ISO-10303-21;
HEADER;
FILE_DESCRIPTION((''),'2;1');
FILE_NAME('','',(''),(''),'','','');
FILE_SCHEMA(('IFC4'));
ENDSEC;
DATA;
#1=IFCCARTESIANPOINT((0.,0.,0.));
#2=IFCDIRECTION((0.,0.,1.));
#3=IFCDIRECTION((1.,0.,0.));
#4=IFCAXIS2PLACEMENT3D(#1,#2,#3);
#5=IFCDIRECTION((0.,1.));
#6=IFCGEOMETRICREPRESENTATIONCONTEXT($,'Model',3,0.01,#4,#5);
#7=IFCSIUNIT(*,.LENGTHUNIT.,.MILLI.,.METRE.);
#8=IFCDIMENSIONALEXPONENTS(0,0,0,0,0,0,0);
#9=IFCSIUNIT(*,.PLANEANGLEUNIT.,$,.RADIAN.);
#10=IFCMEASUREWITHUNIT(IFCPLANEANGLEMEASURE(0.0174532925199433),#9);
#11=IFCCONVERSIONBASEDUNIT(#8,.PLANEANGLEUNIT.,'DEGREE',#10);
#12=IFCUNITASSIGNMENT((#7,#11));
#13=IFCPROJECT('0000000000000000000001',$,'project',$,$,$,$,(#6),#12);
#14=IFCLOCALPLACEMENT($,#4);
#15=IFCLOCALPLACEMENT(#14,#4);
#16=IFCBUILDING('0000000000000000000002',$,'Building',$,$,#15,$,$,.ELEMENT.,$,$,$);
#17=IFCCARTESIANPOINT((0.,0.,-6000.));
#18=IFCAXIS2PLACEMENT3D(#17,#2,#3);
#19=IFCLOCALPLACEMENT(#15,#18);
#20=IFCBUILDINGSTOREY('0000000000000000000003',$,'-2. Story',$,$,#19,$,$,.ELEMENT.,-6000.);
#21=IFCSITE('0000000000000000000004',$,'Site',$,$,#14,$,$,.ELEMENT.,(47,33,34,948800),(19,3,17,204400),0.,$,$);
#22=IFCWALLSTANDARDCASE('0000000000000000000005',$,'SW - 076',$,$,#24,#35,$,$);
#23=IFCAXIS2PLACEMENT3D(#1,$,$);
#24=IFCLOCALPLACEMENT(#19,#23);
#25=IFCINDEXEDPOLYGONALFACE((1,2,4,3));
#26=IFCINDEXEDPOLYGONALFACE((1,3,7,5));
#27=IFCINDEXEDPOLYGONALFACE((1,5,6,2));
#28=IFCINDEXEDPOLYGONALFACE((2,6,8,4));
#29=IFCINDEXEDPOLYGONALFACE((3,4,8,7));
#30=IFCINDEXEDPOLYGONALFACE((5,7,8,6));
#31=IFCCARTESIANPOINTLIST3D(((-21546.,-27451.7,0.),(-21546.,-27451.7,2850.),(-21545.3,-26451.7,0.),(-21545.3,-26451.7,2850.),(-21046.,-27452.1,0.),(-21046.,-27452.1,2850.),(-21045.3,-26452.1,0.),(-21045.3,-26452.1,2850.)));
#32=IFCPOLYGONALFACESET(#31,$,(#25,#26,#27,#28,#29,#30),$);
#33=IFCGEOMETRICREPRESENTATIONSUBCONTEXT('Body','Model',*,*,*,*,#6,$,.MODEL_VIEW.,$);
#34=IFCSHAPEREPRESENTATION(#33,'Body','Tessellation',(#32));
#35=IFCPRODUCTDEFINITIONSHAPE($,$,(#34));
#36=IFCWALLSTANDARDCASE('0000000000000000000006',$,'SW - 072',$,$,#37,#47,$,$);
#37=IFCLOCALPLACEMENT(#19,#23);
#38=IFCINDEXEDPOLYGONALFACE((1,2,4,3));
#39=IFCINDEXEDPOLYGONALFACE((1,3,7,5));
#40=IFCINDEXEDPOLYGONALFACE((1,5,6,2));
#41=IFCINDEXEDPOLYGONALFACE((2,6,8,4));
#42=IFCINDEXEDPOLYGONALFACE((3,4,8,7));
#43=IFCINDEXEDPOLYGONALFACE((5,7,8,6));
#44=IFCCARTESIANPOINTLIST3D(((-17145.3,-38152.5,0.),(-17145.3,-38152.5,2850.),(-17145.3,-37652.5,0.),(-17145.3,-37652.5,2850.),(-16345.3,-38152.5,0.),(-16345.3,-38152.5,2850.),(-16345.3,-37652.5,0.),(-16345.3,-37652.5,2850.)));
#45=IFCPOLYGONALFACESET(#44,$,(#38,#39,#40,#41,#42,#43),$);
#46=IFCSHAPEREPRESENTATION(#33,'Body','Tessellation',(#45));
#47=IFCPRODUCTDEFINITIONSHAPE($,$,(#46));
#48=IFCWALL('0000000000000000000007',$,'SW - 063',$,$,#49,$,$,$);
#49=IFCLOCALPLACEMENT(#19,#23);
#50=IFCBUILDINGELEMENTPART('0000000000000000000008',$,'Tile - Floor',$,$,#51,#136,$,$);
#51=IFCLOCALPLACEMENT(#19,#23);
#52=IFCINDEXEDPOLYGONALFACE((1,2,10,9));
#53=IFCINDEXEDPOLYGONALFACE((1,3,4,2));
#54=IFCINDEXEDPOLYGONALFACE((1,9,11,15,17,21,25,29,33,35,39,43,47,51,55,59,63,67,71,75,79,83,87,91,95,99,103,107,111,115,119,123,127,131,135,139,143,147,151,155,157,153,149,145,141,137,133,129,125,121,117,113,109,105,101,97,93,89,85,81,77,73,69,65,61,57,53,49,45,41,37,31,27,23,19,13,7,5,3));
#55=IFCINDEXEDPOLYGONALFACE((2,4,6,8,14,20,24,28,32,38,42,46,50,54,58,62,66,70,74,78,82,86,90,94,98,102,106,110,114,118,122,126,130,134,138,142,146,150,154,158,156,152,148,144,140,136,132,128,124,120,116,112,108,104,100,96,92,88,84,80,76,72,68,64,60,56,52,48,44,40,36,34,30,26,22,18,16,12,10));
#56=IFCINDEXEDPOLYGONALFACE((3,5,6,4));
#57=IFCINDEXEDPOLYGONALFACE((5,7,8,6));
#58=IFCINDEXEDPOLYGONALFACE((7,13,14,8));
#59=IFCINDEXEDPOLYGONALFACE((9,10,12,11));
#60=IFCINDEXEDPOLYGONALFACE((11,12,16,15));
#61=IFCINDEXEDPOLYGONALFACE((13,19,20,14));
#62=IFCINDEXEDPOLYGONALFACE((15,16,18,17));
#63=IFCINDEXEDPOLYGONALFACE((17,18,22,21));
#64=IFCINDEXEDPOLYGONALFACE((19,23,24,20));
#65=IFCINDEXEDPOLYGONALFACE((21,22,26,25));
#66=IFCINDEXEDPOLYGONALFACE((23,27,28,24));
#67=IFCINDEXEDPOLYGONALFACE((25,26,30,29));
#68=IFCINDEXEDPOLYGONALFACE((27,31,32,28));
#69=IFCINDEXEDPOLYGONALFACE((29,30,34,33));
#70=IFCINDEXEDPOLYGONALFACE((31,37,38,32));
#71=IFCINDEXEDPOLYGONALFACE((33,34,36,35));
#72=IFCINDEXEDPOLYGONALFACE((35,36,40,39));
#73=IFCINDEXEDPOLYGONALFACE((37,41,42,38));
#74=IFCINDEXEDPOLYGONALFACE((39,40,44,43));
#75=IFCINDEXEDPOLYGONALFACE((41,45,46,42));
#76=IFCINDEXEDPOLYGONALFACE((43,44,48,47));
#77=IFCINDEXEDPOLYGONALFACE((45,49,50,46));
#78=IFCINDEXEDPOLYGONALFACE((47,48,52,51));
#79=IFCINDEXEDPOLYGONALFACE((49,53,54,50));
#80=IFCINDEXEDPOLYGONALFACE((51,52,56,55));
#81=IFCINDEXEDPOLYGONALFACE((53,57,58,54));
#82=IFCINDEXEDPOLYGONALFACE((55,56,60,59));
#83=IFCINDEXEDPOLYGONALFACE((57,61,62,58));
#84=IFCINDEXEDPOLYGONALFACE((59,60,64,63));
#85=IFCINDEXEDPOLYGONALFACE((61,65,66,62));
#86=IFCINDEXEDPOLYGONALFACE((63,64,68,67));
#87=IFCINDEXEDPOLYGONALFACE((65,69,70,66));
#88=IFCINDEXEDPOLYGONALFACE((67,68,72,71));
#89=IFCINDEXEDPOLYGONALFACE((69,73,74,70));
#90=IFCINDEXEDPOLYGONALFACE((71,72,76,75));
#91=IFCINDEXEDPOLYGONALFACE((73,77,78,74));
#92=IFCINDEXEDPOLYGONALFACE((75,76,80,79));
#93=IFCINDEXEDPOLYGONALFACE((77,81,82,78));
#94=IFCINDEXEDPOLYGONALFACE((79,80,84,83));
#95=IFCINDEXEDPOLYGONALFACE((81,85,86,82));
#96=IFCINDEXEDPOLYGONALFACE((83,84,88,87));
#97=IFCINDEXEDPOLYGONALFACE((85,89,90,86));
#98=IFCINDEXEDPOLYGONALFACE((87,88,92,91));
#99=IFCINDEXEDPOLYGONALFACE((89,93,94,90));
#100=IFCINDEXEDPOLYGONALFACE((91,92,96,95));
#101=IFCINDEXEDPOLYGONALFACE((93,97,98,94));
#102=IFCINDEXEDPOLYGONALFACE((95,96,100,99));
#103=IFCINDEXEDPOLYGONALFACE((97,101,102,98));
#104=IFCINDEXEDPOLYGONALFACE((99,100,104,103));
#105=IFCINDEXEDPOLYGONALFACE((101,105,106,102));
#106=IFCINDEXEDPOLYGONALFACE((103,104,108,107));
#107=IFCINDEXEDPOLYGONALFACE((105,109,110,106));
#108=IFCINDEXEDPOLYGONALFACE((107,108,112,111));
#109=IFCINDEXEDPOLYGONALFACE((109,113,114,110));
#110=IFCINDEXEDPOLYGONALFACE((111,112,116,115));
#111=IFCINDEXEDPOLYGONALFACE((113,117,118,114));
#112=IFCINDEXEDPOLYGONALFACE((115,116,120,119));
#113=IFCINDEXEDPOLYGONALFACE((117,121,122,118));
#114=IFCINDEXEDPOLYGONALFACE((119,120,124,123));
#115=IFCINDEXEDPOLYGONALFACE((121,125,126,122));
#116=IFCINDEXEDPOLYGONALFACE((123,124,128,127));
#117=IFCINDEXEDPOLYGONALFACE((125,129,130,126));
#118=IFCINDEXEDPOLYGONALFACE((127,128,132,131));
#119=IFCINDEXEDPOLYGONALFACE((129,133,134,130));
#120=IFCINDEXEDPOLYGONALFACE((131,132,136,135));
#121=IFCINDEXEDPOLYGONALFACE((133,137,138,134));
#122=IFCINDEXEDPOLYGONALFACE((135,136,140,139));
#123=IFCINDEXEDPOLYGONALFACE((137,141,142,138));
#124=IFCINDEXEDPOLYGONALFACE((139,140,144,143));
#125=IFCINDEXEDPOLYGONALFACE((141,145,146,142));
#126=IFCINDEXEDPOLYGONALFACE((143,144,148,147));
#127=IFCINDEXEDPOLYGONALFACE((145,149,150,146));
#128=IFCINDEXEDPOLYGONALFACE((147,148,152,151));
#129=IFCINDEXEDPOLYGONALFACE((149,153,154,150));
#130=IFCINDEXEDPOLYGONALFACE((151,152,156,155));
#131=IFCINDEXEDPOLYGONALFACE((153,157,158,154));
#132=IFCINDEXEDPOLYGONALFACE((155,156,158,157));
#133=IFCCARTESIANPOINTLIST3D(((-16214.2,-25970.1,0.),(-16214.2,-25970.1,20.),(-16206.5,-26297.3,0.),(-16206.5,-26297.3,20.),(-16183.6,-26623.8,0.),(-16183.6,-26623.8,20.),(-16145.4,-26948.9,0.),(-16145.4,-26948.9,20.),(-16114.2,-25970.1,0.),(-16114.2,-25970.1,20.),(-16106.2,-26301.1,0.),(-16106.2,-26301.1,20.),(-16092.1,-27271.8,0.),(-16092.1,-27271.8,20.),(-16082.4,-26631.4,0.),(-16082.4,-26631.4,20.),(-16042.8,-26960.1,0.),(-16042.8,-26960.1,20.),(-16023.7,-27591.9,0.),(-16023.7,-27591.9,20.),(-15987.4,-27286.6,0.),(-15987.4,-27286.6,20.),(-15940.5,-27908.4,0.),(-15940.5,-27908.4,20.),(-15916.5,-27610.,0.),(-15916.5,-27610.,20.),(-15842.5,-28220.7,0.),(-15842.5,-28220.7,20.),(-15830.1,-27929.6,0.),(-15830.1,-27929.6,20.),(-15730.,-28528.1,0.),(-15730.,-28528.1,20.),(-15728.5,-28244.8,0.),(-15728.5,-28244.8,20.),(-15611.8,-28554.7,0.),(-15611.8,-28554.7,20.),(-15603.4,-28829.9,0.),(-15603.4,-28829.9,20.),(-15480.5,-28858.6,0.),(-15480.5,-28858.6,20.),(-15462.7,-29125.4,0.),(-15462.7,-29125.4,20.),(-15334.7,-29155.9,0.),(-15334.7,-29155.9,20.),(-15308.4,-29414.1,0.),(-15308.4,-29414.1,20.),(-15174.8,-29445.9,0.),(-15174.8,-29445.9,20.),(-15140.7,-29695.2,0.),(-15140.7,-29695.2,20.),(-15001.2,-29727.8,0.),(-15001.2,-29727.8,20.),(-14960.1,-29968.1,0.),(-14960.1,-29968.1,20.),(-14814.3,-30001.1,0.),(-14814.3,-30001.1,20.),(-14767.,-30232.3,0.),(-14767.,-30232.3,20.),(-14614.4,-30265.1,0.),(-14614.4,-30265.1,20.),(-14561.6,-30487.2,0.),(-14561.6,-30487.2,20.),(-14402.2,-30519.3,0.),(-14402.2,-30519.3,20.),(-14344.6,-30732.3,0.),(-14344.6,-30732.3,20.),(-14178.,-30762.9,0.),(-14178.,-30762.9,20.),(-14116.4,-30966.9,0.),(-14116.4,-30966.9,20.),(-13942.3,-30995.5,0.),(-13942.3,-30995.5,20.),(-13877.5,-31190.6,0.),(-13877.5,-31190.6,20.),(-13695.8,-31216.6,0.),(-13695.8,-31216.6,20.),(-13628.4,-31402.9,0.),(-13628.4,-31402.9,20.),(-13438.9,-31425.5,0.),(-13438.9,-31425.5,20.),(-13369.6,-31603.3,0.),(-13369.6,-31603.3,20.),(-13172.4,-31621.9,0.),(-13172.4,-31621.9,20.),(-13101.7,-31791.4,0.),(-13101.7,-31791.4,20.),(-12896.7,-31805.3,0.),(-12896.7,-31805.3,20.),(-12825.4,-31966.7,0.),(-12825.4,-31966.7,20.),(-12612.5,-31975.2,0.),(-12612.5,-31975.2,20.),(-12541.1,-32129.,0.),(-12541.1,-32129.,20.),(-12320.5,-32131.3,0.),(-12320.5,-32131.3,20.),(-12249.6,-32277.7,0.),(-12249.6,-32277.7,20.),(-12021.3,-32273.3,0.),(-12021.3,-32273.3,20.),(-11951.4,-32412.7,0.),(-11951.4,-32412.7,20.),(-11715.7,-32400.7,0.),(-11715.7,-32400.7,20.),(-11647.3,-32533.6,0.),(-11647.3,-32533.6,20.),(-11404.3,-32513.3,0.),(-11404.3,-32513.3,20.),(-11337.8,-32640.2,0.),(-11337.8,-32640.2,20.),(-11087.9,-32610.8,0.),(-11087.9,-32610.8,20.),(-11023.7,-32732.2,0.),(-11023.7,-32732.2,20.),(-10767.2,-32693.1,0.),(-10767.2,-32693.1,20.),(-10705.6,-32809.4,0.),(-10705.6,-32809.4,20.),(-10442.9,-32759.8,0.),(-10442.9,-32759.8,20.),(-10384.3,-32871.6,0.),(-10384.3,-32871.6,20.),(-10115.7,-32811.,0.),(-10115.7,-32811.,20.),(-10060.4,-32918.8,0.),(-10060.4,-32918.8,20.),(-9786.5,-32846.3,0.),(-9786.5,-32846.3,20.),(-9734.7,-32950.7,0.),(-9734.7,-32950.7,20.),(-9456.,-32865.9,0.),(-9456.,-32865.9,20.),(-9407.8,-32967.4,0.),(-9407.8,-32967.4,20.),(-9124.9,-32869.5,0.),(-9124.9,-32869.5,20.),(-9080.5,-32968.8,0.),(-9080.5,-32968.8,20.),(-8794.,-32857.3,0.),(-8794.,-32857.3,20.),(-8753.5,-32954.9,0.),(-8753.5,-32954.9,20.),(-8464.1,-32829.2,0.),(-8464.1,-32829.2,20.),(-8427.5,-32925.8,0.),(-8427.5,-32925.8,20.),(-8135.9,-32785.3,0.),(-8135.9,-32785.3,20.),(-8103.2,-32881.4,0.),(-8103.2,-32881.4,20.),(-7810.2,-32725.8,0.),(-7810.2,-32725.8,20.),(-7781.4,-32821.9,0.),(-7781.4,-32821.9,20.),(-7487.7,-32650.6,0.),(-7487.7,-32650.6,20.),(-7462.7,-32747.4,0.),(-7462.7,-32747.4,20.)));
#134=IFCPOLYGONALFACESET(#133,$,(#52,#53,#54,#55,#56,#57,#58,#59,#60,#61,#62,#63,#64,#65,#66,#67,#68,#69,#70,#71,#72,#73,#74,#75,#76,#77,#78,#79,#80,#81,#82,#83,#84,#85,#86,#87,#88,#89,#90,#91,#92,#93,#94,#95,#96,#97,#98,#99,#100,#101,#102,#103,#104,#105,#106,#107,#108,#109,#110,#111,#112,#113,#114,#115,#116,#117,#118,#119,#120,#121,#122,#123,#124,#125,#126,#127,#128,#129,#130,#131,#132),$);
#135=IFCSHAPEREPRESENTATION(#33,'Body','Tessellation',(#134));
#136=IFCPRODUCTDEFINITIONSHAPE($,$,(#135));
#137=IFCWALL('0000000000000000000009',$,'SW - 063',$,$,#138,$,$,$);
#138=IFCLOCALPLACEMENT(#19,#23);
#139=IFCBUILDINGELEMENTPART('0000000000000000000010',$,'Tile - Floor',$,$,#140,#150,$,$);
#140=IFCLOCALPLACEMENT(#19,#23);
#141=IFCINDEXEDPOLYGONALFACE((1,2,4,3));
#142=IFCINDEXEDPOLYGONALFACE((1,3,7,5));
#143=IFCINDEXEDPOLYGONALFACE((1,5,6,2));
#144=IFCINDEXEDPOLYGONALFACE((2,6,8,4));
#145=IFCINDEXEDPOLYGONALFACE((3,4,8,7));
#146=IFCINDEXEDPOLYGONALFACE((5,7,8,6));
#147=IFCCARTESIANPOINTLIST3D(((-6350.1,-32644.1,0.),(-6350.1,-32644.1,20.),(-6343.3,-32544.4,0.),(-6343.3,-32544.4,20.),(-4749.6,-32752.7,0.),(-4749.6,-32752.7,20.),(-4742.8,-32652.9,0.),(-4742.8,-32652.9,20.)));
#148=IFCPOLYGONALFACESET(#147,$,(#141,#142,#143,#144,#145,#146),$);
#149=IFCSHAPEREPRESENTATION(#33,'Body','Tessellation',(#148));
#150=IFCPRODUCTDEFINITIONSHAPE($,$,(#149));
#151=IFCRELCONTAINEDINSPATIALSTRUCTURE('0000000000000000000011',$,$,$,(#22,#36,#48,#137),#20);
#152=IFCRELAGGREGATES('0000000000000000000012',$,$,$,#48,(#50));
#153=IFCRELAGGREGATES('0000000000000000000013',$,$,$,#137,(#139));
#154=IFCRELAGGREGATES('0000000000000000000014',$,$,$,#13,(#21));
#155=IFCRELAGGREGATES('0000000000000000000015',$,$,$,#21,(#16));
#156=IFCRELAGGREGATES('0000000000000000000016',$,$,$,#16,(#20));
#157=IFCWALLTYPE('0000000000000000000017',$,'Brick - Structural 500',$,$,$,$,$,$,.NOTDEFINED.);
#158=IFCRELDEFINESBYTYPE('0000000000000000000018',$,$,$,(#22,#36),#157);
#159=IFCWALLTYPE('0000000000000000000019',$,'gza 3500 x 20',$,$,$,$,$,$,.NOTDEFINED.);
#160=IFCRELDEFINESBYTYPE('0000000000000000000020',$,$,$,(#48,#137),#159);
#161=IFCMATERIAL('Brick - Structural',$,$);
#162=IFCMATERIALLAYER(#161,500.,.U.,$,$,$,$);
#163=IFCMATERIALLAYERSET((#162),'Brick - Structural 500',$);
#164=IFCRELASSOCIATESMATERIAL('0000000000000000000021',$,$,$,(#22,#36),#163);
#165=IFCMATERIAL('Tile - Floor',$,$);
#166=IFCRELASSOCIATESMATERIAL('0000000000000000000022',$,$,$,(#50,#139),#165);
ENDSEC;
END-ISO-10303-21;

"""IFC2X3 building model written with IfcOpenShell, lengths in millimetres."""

from ifc_helpers import new_model, entity, si_unit, converted_unit, direction, frame, origin_with_axes, place, context, subcontext, project, spatial, polyline, outline, extrude, material, layer, layer_set, layer_usage, type_object, element, aggregate, save


model = new_model("IFC2X3")

# Units and contexts
model_context = context("Model", 3, precision=0.01, world=origin_with_axes(), true_north=direction((0.0, 1.0)))
body_context = subcontext(model_context, "Body", "Model", "MODEL_VIEW")
ifc_project = project(units=[si_unit("LENGTHUNIT", "METRE", prefix="MILLI"), converted_unit("PLANEANGLEUNIT", "DEGREE", entity("IfcPlaneAngleMeasure", 0.0174532925199433), si_unit("PLANEANGLEUNIT", "RADIAN"), dimensions=[0, 0, 0, 0, 0, 0, 0])], contexts=[model_context])

# Site, building, storey
site_placement = place(None, origin_with_axes())
site = spatial("IfcSite", under=ifc_project, at=site_placement, Name="Site", CompositionType="ELEMENT", RefLatitude=(47, 33, 34, 948800), RefLongitude=(19, 3, 17, 204400), RefElevation=0.0)
building_placement = place(site_placement, origin_with_axes())
building = spatial("IfcBuilding", under=site, at=building_placement, Name="Building", CompositionType="ELEMENT")
storey_placement = place(building_placement, frame((0.0, 0.0, -6000.0), z_axis=(0.0, 0.0, 1.0), x_axis=(1.0, 0.0, 0.0)))
storey = spatial("IfcBuildingStorey", under=building, at=storey_placement, Name="-2. Story", CompositionType="ELEMENT", Elevation=-6000.0)

# Shared definitions
ifc_material_1 = material(Name="Brick - Structural")

# Walls
ifc_layer_1 = layer(ifc_material_1, 500.0, ventilated="UNKNOWN")
ifc_layer_set_1 = layer_set([ifc_layer_1], Name="Brick - Structural 500")
wall_type_1 = type_object("IfcWallType", Name="Brick - Structural 500", PredefinedType="NOTDEFINED")
ifc_layer_usage_1 = layer_usage(ifc_layer_set_1, "AXIS2", "NEGATIVE", 0.0)
wall_1_placement = place(storey_placement, frame((-21546.0, -27451.7, 0.0), z_axis=(0.0, 0.0, 1.0), x_axis=(0.00071, 1.0, 0.0)))
element("IfcWallStandardCase", 1, at=wall_1_placement, inside=storey, type_object=wall_type_1, material=ifc_layer_usage_1, Name="SW - 076", context=body_context, shape_type="SweptSolid", body=[
    extrude(outline(polyline([(0.0, -500.0), (1000.0, -500.0), (1000.0, 0.0), (0.0, 0.0), (0.0, -500.0)])), origin_with_axes(), (0.0, 0.0, 1.0), 2850.0),
])
ifc_layer_usage_2 = layer_usage(ifc_layer_set_1, "AXIS2", "NEGATIVE", 0.0)
wall_2_placement = place(storey_placement, frame((-16345.3, -38152.5, 0.0), z_axis=(0.0, 0.0, 1.0), x_axis=(-1.0, 0.0, 0.0)))
element("IfcWallStandardCase", 2, at=wall_2_placement, inside=storey, type_object=wall_type_1, material=ifc_layer_usage_2, Name="SW - 072", context=body_context, shape_type="SweptSolid", body=[
    extrude(outline(polyline([(0.0, -500.0), (800.0, -500.0), (800.0, 0.0), (0.0, 0.0), (0.0, -500.0)])), origin_with_axes(), (0.0, 0.0, 1.0), 2850.0),
])

# Walls, building element parts
wall_type_2 = type_object("IfcWallType", Name="gza 3500 x 20", PredefinedType="NOTDEFINED")
wall_3_placement = place(storey_placement, frame((-16214.2, -25970.1, 0.0), z_axis=(0.0, 0.0, 1.0), x_axis=(0.0, -1.0, 0.0)))
wall_3 = element("IfcWall", 3, at=wall_3_placement, inside=storey, type_object=wall_type_2, Name="SW - 063")
ifc_material_2 = material(Name="Tile - Floor")
building_element_part_1_placement = place(wall_3_placement, origin_with_axes())
cartesian_point_1 = entity("IfcCartesianPoint", [100.0, 0.0])
building_element_part_1 = element("IfcBuildingElementPart", 4, at=building_element_part_1_placement, material=ifc_material_2, Name="Tile - Floor", context=body_context, shape_type="SweptSolid", body=[
    entity("IfcRevolvedAreaSolid", entity("IfcArbitraryClosedProfileDef", "AREA", None, entity("IfcPolyline", [cartesian_point_1, entity("IfcCartesianPoint", [100.0, 20.0]), entity("IfcCartesianPoint", [0.0, 20.0]), entity("IfcCartesianPoint", [0.0, 0.0]), cartesian_point_1])), entity("IfcAxis2Placement3D", entity("IfcCartesianPoint", [0.0, 0.0, 0.0]), entity("IfcDirection", [1.0, 0.0, 0.0]), entity("IfcDirection", [0.0, 1.0, 0.0])), entity("IfcAxis1Placement", entity("IfcCartesianPoint", [7000.0, 0.0, 0.0]), entity("IfcDirection", [0.0, 1.0, 0.0])), 104.490277),
])
aggregate(wall_3, [building_element_part_1])
wall_4_placement = place(storey_placement, frame((-6350.1, -32644.1, 0.0), z_axis=(0.0, 0.0, 1.0), x_axis=(0.997708, -0.067661, 0.0)))
wall_4 = element("IfcWall", 5, at=wall_4_placement, inside=storey, type_object=wall_type_2, Name="SW - 063")
building_element_part_2_placement = place(wall_4_placement, origin_with_axes())
building_element_part_2 = element("IfcBuildingElementPart", 6, at=building_element_part_2_placement, material=ifc_material_2, Name="Tile - Floor", context=body_context, shape_type="SweptSolid", body=[
    extrude(outline(polyline([(100.0, 0.0), (100.0, 20.0), (0.0, 20.0), (0.0, 0.0), (100.0, 0.0)])), frame((0.0, 0.0, 0.0), z_axis=(1.0, 0.0, 0.0), x_axis=(0.0, 1.0, 0.0)), (0.0, 0.0, 1.0), 1604.2),
])
aggregate(wall_4, [building_element_part_2])

save(model, "model.ifc")
